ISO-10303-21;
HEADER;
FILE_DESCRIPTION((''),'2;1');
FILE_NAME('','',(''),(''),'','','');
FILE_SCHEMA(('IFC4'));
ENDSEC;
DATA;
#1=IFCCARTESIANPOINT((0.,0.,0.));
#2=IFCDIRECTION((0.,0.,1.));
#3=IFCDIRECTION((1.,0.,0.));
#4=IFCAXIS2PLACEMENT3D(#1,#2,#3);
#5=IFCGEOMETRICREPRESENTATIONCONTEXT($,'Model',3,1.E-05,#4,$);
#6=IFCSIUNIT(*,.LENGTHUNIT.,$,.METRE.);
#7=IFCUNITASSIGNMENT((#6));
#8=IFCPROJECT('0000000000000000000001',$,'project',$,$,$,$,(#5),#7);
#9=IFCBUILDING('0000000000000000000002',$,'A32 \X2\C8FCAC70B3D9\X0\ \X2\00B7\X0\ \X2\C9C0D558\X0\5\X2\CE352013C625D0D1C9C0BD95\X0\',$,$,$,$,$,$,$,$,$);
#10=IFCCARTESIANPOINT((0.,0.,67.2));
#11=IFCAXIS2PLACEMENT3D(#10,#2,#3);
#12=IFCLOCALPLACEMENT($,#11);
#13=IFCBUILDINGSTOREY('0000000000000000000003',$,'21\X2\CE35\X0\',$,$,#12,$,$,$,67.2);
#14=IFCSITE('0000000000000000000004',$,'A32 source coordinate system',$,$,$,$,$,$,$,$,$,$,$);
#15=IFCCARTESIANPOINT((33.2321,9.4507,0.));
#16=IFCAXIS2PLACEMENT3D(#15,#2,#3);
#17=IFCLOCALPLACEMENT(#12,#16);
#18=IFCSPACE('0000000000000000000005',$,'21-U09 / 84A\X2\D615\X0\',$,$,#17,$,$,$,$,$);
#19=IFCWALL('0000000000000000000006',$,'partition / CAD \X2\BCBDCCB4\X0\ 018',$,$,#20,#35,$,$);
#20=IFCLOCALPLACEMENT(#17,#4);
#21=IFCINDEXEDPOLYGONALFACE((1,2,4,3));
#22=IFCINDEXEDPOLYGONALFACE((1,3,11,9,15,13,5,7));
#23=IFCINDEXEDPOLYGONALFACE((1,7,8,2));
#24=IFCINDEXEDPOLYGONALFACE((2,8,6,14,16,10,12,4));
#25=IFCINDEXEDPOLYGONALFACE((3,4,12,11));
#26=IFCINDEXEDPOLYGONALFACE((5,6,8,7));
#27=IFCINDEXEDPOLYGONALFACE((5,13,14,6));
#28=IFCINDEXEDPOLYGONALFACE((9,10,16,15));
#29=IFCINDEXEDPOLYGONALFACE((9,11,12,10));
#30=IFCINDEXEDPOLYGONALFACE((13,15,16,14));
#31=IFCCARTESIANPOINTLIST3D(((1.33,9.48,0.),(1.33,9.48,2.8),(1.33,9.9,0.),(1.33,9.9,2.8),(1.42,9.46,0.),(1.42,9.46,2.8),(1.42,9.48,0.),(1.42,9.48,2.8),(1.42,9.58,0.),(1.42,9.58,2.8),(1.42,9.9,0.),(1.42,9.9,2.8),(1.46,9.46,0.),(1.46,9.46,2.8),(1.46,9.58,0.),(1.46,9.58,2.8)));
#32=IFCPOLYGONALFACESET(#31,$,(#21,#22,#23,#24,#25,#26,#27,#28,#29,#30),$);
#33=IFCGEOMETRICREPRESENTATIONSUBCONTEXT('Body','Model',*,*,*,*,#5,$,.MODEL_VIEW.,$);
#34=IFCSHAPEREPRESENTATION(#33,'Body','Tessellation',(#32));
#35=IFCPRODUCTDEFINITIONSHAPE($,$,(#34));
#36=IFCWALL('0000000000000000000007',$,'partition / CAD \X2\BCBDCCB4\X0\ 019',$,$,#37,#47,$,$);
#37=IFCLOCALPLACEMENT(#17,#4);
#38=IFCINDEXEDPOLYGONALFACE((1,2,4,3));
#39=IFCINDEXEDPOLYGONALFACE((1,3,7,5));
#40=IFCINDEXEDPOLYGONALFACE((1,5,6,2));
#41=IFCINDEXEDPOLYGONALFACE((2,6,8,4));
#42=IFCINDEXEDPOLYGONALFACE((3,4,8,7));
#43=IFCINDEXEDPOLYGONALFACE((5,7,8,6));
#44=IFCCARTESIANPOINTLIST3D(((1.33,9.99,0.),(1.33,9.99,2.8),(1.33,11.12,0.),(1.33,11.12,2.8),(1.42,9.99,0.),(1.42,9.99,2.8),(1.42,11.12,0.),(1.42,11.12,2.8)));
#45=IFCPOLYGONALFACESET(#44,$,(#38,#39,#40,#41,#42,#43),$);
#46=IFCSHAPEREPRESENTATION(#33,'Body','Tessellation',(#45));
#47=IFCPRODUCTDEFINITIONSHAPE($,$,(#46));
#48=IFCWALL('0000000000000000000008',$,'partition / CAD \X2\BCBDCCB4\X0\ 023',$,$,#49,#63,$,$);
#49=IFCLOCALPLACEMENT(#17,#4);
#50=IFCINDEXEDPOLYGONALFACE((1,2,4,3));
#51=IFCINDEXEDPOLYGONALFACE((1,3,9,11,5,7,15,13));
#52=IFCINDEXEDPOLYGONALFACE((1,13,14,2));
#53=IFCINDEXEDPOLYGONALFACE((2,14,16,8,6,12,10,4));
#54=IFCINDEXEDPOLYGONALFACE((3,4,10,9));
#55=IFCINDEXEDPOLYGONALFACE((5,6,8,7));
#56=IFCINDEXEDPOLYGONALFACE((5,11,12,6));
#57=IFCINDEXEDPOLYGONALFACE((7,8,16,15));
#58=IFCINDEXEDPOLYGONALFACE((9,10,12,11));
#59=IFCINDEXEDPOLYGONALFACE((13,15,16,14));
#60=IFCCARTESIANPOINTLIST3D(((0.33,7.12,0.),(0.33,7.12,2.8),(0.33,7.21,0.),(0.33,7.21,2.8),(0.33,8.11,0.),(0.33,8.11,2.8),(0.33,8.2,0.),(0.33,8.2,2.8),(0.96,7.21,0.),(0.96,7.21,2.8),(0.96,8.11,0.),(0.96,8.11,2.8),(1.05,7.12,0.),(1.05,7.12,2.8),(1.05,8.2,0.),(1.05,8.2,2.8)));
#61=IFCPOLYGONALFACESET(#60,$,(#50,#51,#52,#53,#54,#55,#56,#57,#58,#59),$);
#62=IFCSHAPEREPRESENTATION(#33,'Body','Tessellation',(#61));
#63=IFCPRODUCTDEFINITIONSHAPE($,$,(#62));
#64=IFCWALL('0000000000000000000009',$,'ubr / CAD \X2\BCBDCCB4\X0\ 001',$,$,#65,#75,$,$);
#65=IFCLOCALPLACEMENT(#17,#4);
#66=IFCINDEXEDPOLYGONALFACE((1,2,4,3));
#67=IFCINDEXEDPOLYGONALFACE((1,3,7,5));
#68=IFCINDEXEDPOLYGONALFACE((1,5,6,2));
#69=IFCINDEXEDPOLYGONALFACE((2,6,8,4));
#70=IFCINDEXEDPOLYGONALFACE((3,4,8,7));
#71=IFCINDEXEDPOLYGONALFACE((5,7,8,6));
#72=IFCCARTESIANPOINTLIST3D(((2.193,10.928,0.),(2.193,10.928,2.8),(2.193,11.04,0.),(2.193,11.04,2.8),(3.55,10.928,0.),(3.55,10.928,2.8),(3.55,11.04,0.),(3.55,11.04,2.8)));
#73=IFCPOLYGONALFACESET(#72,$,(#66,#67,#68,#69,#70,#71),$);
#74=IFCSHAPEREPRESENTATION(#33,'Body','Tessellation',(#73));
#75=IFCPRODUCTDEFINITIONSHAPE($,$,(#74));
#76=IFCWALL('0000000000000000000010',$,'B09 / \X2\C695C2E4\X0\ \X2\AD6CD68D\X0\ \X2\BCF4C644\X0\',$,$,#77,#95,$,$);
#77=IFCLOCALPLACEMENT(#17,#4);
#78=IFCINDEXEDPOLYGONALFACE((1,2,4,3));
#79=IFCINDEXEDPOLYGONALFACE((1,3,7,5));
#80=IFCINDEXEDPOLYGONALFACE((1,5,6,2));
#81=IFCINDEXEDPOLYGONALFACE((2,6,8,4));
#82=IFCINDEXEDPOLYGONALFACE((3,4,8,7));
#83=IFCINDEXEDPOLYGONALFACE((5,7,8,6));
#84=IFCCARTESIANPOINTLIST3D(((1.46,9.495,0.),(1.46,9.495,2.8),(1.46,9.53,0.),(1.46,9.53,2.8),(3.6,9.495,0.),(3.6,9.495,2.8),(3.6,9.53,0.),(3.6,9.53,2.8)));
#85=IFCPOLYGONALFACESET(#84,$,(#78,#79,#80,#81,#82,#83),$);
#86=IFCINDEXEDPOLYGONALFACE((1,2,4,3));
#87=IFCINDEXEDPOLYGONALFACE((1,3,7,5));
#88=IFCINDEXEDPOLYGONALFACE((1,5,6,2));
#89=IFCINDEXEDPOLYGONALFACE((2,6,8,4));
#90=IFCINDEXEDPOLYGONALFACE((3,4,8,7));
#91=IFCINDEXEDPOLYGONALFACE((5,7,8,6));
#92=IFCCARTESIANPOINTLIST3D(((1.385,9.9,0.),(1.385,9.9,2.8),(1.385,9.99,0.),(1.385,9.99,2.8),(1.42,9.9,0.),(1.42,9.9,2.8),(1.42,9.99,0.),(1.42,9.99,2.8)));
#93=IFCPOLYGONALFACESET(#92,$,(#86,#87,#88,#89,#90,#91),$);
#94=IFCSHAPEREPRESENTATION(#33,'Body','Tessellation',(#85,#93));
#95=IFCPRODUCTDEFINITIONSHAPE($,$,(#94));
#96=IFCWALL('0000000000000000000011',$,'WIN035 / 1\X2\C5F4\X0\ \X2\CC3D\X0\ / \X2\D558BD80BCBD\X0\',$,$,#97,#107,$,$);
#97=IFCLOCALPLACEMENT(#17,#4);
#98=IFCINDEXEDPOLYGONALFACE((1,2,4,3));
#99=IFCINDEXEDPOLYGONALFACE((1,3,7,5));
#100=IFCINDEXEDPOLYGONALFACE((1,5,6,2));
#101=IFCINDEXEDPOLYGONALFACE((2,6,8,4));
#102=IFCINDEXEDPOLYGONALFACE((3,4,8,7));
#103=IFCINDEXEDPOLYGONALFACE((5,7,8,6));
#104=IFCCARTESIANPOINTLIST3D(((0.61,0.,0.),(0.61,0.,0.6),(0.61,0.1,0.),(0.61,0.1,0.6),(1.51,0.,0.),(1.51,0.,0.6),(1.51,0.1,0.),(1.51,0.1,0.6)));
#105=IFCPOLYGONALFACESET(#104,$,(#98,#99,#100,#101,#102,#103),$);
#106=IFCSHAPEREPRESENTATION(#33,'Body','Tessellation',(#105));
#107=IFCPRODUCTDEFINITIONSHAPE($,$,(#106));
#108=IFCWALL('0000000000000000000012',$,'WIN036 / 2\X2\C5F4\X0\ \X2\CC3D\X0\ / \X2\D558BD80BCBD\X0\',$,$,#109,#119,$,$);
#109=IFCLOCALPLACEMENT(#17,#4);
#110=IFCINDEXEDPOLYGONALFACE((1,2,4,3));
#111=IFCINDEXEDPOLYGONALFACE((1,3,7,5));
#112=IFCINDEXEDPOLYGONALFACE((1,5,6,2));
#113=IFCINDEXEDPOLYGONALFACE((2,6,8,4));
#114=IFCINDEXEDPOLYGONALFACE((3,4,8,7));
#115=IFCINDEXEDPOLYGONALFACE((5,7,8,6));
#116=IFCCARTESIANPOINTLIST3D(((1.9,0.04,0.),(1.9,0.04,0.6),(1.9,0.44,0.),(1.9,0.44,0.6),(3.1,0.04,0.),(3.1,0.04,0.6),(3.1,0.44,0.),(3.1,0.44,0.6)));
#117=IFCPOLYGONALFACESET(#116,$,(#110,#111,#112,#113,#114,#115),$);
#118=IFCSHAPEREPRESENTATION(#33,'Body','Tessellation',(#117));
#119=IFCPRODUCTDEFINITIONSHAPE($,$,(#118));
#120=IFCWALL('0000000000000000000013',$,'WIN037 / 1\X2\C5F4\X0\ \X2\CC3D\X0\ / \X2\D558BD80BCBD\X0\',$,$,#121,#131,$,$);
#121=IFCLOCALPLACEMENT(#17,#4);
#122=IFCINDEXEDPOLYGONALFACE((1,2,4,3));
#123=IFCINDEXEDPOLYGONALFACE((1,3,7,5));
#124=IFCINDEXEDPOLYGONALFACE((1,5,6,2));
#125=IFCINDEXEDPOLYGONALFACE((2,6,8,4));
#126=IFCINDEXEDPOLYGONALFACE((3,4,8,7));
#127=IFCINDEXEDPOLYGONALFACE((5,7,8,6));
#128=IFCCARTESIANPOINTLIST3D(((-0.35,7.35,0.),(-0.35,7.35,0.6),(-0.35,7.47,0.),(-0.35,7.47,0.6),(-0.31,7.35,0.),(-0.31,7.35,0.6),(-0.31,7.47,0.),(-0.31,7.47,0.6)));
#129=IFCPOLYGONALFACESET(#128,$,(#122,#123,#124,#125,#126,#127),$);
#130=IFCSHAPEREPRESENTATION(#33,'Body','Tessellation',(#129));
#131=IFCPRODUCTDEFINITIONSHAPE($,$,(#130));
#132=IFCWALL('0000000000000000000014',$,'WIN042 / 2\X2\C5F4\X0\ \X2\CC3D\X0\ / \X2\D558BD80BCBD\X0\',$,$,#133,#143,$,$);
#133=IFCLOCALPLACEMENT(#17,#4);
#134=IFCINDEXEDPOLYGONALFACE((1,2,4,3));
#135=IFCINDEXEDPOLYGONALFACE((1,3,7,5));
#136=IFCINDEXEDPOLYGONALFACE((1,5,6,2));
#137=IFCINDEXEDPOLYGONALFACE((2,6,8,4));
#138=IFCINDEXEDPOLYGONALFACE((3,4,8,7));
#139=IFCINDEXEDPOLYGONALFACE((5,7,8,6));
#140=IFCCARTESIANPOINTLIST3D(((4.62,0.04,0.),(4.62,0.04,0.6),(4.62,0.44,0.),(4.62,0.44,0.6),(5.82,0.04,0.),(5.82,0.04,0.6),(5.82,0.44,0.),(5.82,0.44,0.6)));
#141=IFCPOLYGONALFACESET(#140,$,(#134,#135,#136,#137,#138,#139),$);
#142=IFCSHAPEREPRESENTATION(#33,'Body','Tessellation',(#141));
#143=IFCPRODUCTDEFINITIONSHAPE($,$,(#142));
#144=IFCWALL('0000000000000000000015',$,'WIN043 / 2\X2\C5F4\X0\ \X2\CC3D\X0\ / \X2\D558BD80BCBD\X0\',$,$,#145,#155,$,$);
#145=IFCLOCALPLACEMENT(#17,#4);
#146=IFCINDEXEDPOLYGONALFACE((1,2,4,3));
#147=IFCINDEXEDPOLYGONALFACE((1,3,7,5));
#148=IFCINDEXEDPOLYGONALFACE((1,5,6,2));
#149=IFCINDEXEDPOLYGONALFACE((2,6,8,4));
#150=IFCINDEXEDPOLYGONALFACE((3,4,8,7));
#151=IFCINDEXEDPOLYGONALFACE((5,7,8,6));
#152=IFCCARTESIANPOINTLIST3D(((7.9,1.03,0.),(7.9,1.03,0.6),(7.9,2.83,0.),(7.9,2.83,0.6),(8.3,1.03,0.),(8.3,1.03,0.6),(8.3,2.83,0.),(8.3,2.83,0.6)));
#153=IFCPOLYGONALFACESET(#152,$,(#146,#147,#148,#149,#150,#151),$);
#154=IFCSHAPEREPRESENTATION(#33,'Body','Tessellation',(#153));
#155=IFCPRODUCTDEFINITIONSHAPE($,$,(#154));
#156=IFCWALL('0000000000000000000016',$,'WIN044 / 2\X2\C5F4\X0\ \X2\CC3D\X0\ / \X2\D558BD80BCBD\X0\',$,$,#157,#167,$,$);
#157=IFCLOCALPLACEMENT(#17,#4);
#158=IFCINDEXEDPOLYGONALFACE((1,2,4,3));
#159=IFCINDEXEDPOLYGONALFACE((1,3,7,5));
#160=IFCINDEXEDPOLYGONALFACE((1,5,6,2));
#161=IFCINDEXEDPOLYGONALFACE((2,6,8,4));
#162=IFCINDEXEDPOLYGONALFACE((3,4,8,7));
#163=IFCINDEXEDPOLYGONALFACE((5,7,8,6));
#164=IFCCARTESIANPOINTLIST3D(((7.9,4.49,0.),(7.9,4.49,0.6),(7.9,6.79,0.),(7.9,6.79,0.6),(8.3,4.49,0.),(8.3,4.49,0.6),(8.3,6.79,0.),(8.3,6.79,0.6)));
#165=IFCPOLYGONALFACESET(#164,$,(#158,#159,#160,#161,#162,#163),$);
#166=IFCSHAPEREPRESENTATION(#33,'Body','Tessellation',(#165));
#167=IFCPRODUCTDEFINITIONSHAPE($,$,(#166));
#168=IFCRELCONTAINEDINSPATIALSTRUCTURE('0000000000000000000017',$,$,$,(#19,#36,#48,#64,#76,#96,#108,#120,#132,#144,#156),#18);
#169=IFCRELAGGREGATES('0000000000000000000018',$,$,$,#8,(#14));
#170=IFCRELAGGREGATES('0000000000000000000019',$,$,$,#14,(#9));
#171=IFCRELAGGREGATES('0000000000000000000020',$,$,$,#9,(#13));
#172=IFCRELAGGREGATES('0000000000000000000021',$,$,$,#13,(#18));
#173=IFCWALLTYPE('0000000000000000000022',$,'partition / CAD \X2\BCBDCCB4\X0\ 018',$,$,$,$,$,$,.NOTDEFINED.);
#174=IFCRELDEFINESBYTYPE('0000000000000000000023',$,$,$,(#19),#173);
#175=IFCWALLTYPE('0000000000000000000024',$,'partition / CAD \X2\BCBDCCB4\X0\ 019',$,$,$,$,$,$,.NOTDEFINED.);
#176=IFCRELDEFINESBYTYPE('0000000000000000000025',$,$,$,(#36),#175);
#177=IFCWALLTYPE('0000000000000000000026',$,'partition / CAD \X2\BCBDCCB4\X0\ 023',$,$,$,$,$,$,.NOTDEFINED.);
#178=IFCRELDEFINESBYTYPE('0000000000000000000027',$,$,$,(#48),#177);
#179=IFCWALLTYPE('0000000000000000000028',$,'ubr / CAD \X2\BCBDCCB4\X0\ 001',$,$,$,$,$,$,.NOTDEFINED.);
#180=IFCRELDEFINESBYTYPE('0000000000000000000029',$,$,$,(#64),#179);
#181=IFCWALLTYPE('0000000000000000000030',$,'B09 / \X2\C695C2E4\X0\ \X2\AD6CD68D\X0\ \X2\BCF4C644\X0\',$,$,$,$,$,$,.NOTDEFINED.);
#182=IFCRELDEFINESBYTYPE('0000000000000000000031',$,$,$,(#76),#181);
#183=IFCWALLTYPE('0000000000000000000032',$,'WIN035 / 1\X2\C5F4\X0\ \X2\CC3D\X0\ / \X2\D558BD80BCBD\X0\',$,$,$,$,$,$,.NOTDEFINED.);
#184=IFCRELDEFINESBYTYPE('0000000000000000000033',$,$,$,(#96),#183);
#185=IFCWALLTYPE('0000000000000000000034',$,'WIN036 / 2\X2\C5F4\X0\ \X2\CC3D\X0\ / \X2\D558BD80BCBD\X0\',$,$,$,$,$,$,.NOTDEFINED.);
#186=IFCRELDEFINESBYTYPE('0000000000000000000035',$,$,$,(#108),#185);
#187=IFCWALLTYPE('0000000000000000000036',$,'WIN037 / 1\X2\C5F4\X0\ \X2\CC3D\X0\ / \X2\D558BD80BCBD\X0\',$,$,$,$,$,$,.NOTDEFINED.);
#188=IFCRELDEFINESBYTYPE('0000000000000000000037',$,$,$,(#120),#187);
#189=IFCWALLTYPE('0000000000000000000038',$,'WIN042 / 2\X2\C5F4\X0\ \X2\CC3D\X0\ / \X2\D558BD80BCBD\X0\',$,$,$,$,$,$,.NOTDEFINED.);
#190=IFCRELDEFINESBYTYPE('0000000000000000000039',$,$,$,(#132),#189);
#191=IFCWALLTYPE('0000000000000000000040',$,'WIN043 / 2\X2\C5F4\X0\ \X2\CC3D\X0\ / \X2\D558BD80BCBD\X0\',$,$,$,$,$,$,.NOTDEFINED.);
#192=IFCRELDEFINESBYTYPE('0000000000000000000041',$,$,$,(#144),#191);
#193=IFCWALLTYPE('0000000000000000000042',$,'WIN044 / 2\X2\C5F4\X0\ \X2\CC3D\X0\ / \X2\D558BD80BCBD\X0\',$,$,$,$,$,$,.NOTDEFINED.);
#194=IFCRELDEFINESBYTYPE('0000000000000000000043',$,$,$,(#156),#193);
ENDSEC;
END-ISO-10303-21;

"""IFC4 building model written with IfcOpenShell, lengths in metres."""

from ifc_helpers import new_model, si_unit, frame, origin, origin_with_axes, place, context, subcontext, project, spatial, polyline, outline, extrude, source, transform, mapped, type_object, type_shapes, element, save


model = new_model("IFC4")

# Units and contexts
model_context = context("Model", 3, precision=1e-05, world=origin_with_axes())
body_context = subcontext(model_context, "Body", "Model", "MODEL_VIEW")
ifc_project = project(units=[si_unit("LENGTHUNIT", "METRE")], contexts=[model_context])

# Site, building, storey, space
site = spatial("IfcSite", under=ifc_project, Name="A32 source coordinate system")
building = spatial("IfcBuilding", under=site, Name="A32 주거동 · 지하5층–옥탑지붕")
storey_placement = place(None, frame((0.0, 0.0, 67.2), z_axis=(0.0, 0.0, 1.0), x_axis=(1.0, 0.0, 0.0)))
storey = spatial("IfcBuildingStorey", under=building, at=storey_placement, Name="21층", Elevation=67.2)
space_1_placement = place(storey_placement, frame((33.2321, 9.4507, 0.0), z_axis=(0.0, 0.0, 1.0), x_axis=(1.0, 0.0, 0.0)))
space_1 = spatial("IfcSpace", under=storey, at=space_1_placement, Name="21-U09 / 84A형")

# Walls
wall_type_1 = type_object("IfcWallType", Name="partition / CAD 벽체 018", PredefinedType="NOTDEFINED")
shared_shape_1 = source(origin(), body_context, "Body", "SweptSolid", [
    extrude(outline(polyline([(1.42, 9.58), (1.46, 9.58), (1.46, 9.46), (1.42, 9.46), (1.42, 9.48), (1.33, 9.48), (1.33, 9.9), (1.42, 9.9), (1.42, 9.58)])), origin(), (0.0, 0.0, 1.0), 2.8),
])
type_shapes(wall_type_1, [shared_shape_1])
wall_1_placement = place(space_1_placement, origin_with_axes())
element("IfcWall", 1, at=wall_1_placement, inside=space_1, type_object=wall_type_1, Name="partition / CAD 벽체 018", context=body_context, shape_type="MappedRepresentation", body=[
    mapped(shared_shape_1, transform((0.0, 0.0, 0.0), scale=1.0)),
])
wall_type_2 = type_object("IfcWallType", Name="partition / CAD 벽체 019", PredefinedType="NOTDEFINED")
shared_shape_2 = source(origin(), body_context, "Body", "SweptSolid", [
    extrude(outline(polyline([(1.33, 11.12), (1.42, 11.12), (1.42, 9.99), (1.33, 9.99), (1.33, 11.12)])), origin(), (0.0, 0.0, 1.0), 2.8),
])
type_shapes(wall_type_2, [shared_shape_2])
wall_2_placement = place(space_1_placement, origin_with_axes())
element("IfcWall", 2, at=wall_2_placement, inside=space_1, type_object=wall_type_2, Name="partition / CAD 벽체 019", context=body_context, shape_type="MappedRepresentation", body=[
    mapped(shared_shape_2, transform((0.0, 0.0, 0.0), scale=1.0)),
])
wall_type_3 = type_object("IfcWallType", Name="partition / CAD 벽체 023", PredefinedType="NOTDEFINED")
shared_shape_3 = source(origin(), body_context, "Body", "SweptSolid", [
    extrude(outline(polyline([(0.96, 8.11), (0.33, 8.11), (0.33, 8.2), (1.05, 8.2), (1.05, 7.12), (0.33, 7.12), (0.33, 7.21), (0.96, 7.21), (0.96, 8.11)])), origin(), (0.0, 0.0, 1.0), 2.8),
])
type_shapes(wall_type_3, [shared_shape_3])
wall_3_placement = place(space_1_placement, origin_with_axes())
element("IfcWall", 3, at=wall_3_placement, inside=space_1, type_object=wall_type_3, Name="partition / CAD 벽체 023", context=body_context, shape_type="MappedRepresentation", body=[
    mapped(shared_shape_3, transform((0.0, 0.0, 0.0), scale=1.0)),
])
wall_type_4 = type_object("IfcWallType", Name="ubr / CAD 벽체 001", PredefinedType="NOTDEFINED")
shared_shape_4 = source(origin(), body_context, "Body", "SweptSolid", [
    extrude(outline(polyline([(3.55, 11.04), (3.55, 10.928), (2.193, 10.928), (2.193, 11.04), (3.55, 11.04)])), origin(), (0.0, 0.0, 1.0), 2.8),
])
type_shapes(wall_type_4, [shared_shape_4])
wall_4_placement = place(space_1_placement, origin_with_axes())
element("IfcWall", 4, at=wall_4_placement, inside=space_1, type_object=wall_type_4, Name="ubr / CAD 벽체 001", context=body_context, shape_type="MappedRepresentation", body=[
    mapped(shared_shape_4, transform((0.0, 0.0, 0.0), scale=1.0)),
])
wall_type_5 = type_object("IfcWallType", Name="B09 / 욕실 구획 보완", PredefinedType="NOTDEFINED")
shared_shape_5 = source(origin(), body_context, "Body", "SweptSolid", [
    extrude(outline(polyline([(3.6, 9.53), (3.6, 9.495), (1.46, 9.495), (1.46, 9.53), (3.6, 9.53)])), origin(), (0.0, 0.0, 1.0), 2.8),
    extrude(outline(polyline([(1.42, 9.9), (1.385, 9.9), (1.385, 9.99), (1.42, 9.99), (1.42, 9.9)])), origin(), (0.0, 0.0, 1.0), 2.8),
])
type_shapes(wall_type_5, [shared_shape_5])
wall_5_placement = place(space_1_placement, origin_with_axes())
element("IfcWall", 5, at=wall_5_placement, inside=space_1, type_object=wall_type_5, Name="B09 / 욕실 구획 보완", context=body_context, shape_type="MappedRepresentation", body=[
    mapped(shared_shape_5, transform((0.0, 0.0, 0.0), scale=1.0)),
])
wall_type_6 = type_object("IfcWallType", Name="WIN035 / 1열 창 / 하부벽", PredefinedType="NOTDEFINED")
shared_shape_6 = source(origin(), body_context, "Body", "SweptSolid", [
    extrude(outline(polyline([(0.61, 0.1), (1.51, 0.1), (1.51, 0.0), (0.61, 0.0), (0.61, 0.1)])), origin(), (0.0, 0.0, 1.0), 0.6),
])
type_shapes(wall_type_6, [shared_shape_6])
wall_6_placement = place(space_1_placement, origin_with_axes())
element("IfcWall", 6, at=wall_6_placement, inside=space_1, type_object=wall_type_6, Name="WIN035 / 1열 창 / 하부벽", context=body_context, shape_type="MappedRepresentation", body=[
    mapped(shared_shape_6, transform((0.0, 0.0, 0.0), scale=1.0)),
])
wall_type_7 = type_object("IfcWallType", Name="WIN036 / 2열 창 / 하부벽", PredefinedType="NOTDEFINED")
shared_shape_7 = source(origin(), body_context, "Body", "SweptSolid", [
    extrude(outline(polyline([(1.9, 0.44), (3.1, 0.44), (3.1, 0.04), (1.9, 0.04), (1.9, 0.44)])), origin(), (0.0, 0.0, 1.0), 0.6),
])
type_shapes(wall_type_7, [shared_shape_7])
wall_7_placement = place(space_1_placement, origin_with_axes())
element("IfcWall", 7, at=wall_7_placement, inside=space_1, type_object=wall_type_7, Name="WIN036 / 2열 창 / 하부벽", context=body_context, shape_type="MappedRepresentation", body=[
    mapped(shared_shape_7, transform((0.0, 0.0, 0.0), scale=1.0)),
])
wall_type_8 = type_object("IfcWallType", Name="WIN037 / 1열 창 / 하부벽", PredefinedType="NOTDEFINED")
shared_shape_8 = source(origin(), body_context, "Body", "SweptSolid", [
    extrude(outline(polyline([(-0.31, 7.47), (-0.31, 7.35), (-0.35, 7.35), (-0.35, 7.47), (-0.31, 7.47)])), origin(), (0.0, 0.0, 1.0), 0.6),
])
type_shapes(wall_type_8, [shared_shape_8])
wall_8_placement = place(space_1_placement, origin_with_axes())
element("IfcWall", 8, at=wall_8_placement, inside=space_1, type_object=wall_type_8, Name="WIN037 / 1열 창 / 하부벽", context=body_context, shape_type="MappedRepresentation", body=[
    mapped(shared_shape_8, transform((0.0, 0.0, 0.0), scale=1.0)),
])
wall_type_9 = type_object("IfcWallType", Name="WIN042 / 2열 창 / 하부벽", PredefinedType="NOTDEFINED")
shared_shape_9 = source(origin(), body_context, "Body", "SweptSolid", [
    extrude(outline(polyline([(4.62, 0.44), (5.82, 0.44), (5.82, 0.04), (4.62, 0.04), (4.62, 0.44)])), origin(), (0.0, 0.0, 1.0), 0.6),
])
type_shapes(wall_type_9, [shared_shape_9])
wall_9_placement = place(space_1_placement, origin_with_axes())
element("IfcWall", 9, at=wall_9_placement, inside=space_1, type_object=wall_type_9, Name="WIN042 / 2열 창 / 하부벽", context=body_context, shape_type="MappedRepresentation", body=[
    mapped(shared_shape_9, transform((0.0, 0.0, 0.0), scale=1.0)),
])
wall_type_10 = type_object("IfcWallType", Name="WIN043 / 2열 창 / 하부벽", PredefinedType="NOTDEFINED")
shared_shape_10 = source(origin(), body_context, "Body", "SweptSolid", [
    extrude(outline(polyline([(7.9, 2.83), (8.3, 2.83), (8.3, 1.03), (7.9, 1.03), (7.9, 2.83)])), origin(), (0.0, 0.0, 1.0), 0.6),
])
type_shapes(wall_type_10, [shared_shape_10])
wall_10_placement = place(space_1_placement, origin_with_axes())
element("IfcWall", 10, at=wall_10_placement, inside=space_1, type_object=wall_type_10, Name="WIN043 / 2열 창 / 하부벽", context=body_context, shape_type="MappedRepresentation", body=[
    mapped(shared_shape_10, transform((0.0, 0.0, 0.0), scale=1.0)),
])
wall_type_11 = type_object("IfcWallType", Name="WIN044 / 2열 창 / 하부벽", PredefinedType="NOTDEFINED")
shared_shape_11 = source(origin(), body_context, "Body", "SweptSolid", [
    extrude(outline(polyline([(7.9, 6.79), (8.3, 6.79), (8.3, 4.49), (7.9, 4.49), (7.9, 6.79)])), origin(), (0.0, 0.0, 1.0), 0.6),
])
type_shapes(wall_type_11, [shared_shape_11])
wall_11_placement = place(space_1_placement, origin_with_axes())
element("IfcWall", 11, at=wall_11_placement, inside=space_1, type_object=wall_type_11, Name="WIN044 / 2열 창 / 하부벽", context=body_context, shape_type="MappedRepresentation", body=[
    mapped(shared_shape_11, transform((0.0, 0.0, 0.0), scale=1.0)),
])

save(model, "model.ifc")
